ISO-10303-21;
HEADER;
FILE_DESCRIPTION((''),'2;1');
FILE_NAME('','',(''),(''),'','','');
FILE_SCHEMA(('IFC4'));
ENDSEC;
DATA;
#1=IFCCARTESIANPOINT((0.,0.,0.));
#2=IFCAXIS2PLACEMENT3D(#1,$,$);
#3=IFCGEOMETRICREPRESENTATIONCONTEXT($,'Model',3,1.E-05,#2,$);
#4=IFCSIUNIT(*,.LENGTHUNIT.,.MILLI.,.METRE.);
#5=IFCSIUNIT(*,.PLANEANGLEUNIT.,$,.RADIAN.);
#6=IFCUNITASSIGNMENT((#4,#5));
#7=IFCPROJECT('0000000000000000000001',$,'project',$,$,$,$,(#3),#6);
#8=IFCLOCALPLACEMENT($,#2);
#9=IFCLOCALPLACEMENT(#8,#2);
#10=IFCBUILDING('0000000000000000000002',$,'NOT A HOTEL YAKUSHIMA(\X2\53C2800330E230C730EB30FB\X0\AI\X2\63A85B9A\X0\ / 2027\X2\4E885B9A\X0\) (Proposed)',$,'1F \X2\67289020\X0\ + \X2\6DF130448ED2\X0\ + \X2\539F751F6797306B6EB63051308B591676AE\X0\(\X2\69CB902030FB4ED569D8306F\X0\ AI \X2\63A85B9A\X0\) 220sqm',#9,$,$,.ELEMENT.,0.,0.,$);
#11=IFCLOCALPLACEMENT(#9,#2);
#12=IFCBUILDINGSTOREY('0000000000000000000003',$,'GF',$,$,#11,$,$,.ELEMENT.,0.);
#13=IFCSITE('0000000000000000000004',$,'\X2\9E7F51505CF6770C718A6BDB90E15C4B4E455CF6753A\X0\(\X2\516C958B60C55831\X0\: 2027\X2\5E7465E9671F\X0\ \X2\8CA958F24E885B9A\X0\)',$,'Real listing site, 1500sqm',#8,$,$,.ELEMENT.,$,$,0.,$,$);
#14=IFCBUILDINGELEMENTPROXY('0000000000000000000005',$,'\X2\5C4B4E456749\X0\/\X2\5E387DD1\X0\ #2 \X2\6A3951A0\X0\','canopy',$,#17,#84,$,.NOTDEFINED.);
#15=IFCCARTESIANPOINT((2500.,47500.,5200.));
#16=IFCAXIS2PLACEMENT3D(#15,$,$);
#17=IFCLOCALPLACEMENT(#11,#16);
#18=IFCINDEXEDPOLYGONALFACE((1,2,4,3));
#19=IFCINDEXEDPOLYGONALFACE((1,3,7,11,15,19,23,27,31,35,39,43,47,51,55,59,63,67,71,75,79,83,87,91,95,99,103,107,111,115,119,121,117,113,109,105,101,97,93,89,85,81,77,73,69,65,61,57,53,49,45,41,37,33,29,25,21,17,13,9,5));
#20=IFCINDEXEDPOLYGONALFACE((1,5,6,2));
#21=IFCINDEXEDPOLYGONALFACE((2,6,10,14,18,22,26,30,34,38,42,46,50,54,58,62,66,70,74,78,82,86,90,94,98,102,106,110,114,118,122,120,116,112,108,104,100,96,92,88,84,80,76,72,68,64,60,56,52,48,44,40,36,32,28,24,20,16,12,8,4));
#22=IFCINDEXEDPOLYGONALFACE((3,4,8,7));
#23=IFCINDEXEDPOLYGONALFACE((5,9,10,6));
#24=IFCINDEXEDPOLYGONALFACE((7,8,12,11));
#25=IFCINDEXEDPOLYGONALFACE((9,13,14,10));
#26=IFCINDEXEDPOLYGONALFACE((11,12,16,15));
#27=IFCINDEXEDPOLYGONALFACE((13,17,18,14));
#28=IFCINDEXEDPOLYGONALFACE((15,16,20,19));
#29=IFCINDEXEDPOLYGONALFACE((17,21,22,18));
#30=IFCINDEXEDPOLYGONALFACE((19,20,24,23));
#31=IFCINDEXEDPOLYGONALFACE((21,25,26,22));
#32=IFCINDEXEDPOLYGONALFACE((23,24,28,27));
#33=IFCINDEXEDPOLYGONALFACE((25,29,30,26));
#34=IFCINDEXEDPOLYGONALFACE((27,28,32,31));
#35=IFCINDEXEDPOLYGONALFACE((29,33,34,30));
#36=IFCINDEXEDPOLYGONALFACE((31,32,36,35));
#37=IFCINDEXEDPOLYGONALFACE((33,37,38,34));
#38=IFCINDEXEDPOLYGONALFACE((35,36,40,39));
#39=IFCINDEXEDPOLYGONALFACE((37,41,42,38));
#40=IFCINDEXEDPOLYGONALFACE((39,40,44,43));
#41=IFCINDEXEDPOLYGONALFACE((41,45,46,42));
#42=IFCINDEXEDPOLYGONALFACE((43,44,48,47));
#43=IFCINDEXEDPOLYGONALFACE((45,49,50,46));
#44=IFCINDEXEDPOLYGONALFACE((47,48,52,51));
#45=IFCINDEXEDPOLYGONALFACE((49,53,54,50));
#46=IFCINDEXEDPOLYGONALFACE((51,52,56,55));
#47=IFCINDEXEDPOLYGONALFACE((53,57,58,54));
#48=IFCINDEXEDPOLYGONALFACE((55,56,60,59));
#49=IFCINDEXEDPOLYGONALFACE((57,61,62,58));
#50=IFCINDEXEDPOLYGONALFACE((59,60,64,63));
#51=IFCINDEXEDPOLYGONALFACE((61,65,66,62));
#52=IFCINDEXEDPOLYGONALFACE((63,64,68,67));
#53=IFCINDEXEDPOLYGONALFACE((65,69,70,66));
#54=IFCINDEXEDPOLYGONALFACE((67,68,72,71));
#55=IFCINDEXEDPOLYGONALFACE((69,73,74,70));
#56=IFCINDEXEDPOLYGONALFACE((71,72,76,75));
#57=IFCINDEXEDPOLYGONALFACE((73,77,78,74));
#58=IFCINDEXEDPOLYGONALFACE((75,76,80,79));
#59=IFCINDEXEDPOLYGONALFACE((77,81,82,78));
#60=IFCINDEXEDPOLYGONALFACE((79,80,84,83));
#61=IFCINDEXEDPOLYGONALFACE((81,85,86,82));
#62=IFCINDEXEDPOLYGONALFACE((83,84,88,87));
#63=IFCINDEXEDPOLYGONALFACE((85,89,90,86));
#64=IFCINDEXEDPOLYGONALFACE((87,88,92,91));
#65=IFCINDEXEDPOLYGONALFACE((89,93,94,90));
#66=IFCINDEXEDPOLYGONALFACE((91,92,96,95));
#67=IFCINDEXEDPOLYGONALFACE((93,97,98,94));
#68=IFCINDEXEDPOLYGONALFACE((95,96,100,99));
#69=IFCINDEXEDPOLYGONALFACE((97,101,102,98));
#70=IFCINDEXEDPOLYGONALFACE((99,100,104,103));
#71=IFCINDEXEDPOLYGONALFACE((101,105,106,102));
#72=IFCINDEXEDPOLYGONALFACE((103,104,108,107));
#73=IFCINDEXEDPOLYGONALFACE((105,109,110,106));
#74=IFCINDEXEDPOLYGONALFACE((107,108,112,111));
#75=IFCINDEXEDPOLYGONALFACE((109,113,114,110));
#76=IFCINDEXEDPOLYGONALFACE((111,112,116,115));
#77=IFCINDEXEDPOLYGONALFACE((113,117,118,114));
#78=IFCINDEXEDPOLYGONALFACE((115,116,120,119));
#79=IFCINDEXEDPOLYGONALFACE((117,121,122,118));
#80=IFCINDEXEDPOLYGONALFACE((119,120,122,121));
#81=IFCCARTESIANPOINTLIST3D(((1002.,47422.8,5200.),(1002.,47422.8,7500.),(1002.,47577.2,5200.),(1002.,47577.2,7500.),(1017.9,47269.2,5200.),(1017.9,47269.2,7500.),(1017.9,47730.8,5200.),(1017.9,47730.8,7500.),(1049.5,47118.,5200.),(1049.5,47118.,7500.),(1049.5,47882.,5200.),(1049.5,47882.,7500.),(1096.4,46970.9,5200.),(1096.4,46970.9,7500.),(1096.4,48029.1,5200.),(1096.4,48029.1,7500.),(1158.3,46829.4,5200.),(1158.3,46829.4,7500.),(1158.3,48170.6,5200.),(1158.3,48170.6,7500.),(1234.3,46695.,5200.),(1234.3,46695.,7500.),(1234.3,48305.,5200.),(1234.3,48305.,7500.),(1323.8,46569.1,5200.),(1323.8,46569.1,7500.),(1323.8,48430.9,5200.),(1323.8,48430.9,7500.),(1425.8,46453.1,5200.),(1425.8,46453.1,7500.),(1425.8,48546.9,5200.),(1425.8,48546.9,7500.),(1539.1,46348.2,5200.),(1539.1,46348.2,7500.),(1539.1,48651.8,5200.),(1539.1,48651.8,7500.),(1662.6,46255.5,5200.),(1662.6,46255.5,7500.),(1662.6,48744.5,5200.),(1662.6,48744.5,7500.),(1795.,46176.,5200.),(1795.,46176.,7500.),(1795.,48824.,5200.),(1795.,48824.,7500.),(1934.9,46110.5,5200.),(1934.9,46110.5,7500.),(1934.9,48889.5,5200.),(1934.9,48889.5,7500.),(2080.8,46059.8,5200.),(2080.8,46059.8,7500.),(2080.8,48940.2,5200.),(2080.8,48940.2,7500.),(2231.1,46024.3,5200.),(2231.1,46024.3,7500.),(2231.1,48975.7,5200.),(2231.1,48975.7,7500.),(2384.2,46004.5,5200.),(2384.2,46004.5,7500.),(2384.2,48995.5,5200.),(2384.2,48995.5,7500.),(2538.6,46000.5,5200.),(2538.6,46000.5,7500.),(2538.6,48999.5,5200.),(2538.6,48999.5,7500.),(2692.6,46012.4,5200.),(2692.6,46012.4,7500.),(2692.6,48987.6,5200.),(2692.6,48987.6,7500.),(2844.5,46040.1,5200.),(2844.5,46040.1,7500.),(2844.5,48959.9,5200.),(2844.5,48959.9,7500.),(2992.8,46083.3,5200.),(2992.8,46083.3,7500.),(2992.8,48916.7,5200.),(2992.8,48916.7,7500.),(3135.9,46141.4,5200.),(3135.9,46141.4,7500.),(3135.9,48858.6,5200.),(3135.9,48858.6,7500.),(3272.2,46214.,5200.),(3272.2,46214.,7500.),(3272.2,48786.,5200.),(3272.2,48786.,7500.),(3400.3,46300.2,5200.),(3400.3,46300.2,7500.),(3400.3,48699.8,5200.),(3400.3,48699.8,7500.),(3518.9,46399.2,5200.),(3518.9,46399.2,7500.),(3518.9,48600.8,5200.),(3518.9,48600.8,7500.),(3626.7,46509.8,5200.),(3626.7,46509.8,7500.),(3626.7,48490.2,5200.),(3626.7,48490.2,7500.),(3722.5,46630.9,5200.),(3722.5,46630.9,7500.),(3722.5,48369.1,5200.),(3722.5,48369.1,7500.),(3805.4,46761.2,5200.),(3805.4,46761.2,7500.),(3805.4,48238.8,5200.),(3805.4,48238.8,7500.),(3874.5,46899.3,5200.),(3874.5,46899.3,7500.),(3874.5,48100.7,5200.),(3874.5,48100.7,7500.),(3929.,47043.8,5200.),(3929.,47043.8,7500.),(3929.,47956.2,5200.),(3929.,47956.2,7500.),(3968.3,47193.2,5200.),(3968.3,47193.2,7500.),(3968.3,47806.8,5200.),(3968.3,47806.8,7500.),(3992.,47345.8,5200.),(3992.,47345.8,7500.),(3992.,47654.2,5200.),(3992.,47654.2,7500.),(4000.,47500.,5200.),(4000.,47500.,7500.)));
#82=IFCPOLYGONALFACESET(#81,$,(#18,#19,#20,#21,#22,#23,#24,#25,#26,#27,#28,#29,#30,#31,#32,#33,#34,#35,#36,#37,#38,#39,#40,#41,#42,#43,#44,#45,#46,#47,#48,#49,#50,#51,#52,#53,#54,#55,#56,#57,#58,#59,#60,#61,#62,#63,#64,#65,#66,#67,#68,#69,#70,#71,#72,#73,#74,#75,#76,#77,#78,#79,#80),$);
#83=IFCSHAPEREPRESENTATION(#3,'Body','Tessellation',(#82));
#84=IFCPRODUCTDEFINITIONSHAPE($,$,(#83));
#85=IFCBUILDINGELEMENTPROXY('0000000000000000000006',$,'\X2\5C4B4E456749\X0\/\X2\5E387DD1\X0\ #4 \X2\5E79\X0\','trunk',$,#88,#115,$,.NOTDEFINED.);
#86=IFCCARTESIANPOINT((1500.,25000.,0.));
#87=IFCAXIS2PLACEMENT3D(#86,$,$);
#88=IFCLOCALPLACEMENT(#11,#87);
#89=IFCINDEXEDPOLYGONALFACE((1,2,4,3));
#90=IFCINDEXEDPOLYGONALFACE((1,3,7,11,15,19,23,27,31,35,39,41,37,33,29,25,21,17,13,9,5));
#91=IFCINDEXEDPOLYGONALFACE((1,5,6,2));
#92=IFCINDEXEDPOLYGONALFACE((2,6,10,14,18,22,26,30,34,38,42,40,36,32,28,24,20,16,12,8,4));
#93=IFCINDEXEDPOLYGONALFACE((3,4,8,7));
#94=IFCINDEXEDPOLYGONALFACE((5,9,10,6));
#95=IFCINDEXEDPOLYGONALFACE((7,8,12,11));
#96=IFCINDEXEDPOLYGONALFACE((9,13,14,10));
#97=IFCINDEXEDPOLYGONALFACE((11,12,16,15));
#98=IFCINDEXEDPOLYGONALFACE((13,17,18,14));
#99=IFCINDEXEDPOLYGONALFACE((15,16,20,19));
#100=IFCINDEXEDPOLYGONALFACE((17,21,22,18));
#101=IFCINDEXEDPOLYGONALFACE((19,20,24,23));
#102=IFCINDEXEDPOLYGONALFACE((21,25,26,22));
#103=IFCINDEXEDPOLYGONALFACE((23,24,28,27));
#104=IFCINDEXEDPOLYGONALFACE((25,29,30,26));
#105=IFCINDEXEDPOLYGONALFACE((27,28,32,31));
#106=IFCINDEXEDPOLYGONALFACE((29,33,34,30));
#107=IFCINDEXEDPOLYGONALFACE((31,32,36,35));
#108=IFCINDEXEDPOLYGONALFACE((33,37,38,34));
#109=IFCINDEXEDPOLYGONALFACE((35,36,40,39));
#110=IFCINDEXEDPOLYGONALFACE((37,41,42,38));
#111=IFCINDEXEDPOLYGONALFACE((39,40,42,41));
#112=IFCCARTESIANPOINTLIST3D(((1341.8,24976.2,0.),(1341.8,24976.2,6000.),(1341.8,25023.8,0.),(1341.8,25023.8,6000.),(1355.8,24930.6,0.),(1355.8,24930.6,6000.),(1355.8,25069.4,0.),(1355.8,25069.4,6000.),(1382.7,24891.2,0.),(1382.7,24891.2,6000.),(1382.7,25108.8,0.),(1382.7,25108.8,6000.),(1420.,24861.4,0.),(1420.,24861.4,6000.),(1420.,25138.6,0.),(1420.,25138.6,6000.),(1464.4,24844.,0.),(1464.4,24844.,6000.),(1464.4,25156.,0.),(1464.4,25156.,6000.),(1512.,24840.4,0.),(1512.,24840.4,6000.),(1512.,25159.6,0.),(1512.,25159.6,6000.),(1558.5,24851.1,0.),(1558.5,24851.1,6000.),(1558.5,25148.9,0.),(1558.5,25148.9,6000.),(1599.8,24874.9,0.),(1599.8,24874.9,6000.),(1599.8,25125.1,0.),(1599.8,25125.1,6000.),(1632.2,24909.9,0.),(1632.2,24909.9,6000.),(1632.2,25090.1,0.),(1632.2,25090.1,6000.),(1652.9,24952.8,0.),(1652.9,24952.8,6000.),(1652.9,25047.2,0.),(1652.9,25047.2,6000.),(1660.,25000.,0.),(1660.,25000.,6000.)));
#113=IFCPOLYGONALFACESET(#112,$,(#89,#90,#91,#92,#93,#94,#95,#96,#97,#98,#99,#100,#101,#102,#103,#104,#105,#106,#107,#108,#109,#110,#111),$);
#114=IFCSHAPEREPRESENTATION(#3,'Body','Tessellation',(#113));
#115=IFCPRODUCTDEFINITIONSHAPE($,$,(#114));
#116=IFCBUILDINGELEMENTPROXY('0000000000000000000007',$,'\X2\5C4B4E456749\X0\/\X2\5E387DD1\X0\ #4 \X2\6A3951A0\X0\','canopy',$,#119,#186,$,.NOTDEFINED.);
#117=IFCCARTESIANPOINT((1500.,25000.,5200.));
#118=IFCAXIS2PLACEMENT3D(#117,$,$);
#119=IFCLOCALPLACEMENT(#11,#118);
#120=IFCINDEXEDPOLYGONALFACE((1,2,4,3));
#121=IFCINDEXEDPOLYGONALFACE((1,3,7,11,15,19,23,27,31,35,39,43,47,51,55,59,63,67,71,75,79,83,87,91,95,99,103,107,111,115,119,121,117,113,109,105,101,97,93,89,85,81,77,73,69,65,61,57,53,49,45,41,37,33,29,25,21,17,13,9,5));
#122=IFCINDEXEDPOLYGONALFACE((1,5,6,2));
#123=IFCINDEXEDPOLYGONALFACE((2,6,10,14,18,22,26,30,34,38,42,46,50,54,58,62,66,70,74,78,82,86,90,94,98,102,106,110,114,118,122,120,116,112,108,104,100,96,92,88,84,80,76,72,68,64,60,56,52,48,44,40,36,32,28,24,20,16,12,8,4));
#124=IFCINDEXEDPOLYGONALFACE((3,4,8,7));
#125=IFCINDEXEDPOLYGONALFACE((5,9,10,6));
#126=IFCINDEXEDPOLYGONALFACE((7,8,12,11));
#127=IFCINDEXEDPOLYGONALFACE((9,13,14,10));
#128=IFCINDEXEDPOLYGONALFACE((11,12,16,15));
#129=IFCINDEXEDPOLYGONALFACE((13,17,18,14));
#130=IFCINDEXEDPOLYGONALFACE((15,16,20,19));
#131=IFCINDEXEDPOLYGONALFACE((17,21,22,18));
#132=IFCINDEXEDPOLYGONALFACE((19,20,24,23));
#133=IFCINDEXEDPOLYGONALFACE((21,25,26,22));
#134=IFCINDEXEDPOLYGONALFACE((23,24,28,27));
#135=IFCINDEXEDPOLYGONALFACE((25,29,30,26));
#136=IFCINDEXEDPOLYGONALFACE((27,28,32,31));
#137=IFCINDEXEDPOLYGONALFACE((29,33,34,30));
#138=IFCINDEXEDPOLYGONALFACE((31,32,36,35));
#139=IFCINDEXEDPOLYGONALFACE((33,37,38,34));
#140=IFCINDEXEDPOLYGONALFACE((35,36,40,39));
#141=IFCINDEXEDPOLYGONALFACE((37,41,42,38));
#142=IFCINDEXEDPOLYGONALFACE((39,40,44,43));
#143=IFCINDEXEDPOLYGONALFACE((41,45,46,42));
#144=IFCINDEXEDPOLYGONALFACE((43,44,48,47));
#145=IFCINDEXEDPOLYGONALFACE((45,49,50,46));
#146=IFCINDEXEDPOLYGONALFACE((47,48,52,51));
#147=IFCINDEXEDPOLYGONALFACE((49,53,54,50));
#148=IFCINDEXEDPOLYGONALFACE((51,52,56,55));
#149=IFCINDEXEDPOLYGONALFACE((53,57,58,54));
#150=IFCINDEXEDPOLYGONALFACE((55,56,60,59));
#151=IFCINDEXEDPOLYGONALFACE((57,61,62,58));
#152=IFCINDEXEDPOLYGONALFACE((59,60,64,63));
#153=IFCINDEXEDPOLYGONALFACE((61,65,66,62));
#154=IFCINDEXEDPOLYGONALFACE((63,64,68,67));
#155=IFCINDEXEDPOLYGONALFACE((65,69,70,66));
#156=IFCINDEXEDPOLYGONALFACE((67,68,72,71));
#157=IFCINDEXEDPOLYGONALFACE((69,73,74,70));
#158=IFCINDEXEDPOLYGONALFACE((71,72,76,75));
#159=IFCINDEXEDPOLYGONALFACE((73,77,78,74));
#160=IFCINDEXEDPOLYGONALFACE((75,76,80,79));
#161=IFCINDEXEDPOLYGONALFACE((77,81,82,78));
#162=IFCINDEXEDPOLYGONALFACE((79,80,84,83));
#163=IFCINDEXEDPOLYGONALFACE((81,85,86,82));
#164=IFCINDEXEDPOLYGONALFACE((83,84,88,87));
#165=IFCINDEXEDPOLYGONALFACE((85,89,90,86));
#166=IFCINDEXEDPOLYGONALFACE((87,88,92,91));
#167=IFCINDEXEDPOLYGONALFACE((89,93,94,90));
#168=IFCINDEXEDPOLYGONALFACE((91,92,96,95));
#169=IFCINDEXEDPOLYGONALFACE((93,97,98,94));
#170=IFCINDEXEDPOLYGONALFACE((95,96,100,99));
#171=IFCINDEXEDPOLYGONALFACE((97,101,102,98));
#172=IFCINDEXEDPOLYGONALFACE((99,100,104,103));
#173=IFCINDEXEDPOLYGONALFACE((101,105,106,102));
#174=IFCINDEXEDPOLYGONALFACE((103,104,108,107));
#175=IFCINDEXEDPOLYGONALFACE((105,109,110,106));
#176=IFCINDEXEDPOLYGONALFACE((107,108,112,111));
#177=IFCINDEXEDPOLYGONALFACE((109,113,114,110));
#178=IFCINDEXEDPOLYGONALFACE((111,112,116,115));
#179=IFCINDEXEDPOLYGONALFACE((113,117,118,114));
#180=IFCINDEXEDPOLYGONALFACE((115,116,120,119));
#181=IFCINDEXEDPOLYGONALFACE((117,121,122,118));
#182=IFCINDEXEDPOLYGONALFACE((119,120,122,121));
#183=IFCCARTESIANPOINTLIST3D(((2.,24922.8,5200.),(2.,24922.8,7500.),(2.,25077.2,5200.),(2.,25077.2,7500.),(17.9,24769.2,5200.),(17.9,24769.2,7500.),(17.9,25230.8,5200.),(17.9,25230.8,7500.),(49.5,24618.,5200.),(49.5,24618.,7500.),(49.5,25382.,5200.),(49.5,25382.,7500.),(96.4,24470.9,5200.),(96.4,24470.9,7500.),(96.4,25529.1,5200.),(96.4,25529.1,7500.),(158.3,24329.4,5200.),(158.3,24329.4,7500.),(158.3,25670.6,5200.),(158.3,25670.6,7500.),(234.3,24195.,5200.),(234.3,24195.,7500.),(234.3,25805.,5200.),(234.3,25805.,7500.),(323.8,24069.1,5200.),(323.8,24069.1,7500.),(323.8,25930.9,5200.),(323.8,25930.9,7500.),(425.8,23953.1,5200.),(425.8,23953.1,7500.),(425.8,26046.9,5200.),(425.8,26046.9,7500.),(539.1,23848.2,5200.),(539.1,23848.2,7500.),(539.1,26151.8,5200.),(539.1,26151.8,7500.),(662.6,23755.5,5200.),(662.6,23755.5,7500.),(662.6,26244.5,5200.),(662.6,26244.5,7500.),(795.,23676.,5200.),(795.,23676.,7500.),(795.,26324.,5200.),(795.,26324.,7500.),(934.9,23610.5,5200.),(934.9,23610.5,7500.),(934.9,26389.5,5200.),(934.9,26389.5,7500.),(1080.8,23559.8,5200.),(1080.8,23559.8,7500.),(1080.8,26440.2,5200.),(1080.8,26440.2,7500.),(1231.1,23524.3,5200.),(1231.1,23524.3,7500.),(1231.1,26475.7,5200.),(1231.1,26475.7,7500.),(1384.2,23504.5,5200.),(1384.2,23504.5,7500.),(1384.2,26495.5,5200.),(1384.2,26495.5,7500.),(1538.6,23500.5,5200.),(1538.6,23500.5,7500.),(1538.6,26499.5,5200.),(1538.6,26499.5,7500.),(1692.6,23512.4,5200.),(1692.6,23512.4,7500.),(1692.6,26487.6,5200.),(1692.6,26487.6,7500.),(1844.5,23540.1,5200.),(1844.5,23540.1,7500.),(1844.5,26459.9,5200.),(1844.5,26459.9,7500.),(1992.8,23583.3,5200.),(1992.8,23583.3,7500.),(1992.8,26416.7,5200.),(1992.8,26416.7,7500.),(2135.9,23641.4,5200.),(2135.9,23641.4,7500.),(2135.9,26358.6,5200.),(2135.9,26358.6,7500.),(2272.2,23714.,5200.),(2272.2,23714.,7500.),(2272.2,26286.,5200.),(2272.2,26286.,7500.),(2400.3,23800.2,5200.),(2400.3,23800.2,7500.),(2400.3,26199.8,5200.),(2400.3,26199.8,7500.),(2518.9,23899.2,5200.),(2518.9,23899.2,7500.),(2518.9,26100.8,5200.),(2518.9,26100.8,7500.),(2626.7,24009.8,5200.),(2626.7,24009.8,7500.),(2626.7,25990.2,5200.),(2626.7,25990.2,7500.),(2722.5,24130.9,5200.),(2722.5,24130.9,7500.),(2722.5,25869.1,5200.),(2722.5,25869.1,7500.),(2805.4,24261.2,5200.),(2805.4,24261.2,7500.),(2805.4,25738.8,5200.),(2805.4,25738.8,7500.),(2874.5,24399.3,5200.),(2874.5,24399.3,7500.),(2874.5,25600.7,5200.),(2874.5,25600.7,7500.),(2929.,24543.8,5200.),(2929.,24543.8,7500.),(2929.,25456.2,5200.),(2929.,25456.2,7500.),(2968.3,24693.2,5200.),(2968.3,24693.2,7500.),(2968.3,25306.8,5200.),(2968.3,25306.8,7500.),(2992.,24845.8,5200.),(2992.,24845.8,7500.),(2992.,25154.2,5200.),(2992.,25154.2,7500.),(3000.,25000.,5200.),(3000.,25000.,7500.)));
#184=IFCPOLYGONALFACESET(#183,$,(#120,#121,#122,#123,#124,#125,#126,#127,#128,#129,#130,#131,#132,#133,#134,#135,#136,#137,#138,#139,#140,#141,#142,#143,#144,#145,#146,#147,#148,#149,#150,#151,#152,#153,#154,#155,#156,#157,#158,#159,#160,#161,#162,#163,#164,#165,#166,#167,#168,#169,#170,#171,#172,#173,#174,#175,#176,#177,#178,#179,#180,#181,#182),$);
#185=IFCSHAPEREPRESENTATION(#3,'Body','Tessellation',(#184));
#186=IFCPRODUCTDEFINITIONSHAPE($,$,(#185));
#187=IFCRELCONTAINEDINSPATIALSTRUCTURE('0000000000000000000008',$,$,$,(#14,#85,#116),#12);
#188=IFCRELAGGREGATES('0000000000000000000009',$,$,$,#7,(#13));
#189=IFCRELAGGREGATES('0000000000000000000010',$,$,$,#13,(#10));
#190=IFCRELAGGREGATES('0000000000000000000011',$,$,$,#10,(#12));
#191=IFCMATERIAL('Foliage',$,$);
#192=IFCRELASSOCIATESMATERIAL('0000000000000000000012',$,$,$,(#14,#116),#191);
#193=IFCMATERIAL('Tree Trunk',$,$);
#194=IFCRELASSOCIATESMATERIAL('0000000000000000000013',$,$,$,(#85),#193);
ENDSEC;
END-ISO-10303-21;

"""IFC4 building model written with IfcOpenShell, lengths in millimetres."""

from ifc_helpers import new_model, si_unit, frame, origin, origin_2d, place, context, project, spatial, circle, extrude, material, element, save


model = new_model("IFC4")

# Units and contexts
model_context = context("Model", 3, precision=1e-05, world=origin())
ifc_project = project(units=[si_unit("LENGTHUNIT", "METRE", prefix="MILLI"), si_unit("PLANEANGLEUNIT", "RADIAN")], contexts=[model_context])

# Site, building, storey
site_placement = place(None, origin())
site = spatial("IfcSite", under=ifc_project, at=site_placement, Name="鹿児島県熊毛郡屋久島町(公開情報: 2027年早期 販売予定)", ObjectType="Real listing site, 1500sqm", CompositionType="ELEMENT", RefElevation=0.0)
building_placement = place(site_placement, origin())
building = spatial("IfcBuilding", under=site, at=building_placement, Name="NOT A HOTEL YAKUSHIMA(参考モデル・AI推定 / 2027予定) (Proposed)", ObjectType="1F 木造 + 深い軒 + 原生林に溶ける外皮(構造・仕様は AI 推定) 220sqm", CompositionType="ELEMENT", ElevationOfRefHeight=0.0, ElevationOfTerrain=0.0)
storey_placement = place(building_placement, origin())
storey = spatial("IfcBuildingStorey", under=building, at=storey_placement, Name="GF", CompositionType="ELEMENT", Elevation=0.0)

# Building element proxies
ifc_material_1 = material(Name="Tree Trunk")
ifc_material_2 = material(Name="Foliage")
proxy_1_placement = place(storey_placement, frame((2500.0, 47500.0, 5200.0)))
element("IfcBuildingElementProxy", 1, at=proxy_1_placement, inside=storey, material=ifc_material_2, Name="屋久杉/常緑 #2 樹冠", Description="canopy", PredefinedType="NOTDEFINED", context=model_context, shape_type="SweptSolid", body=[
    extrude(circle(Radius=1500.0, at=origin_2d()), frame((2500.0, 47500.0, 5200.0)), (0.0, 0.0, 1.0), 2300.0),
])
proxy_2_placement = place(storey_placement, frame((1500.0, 25000.0, 0.0)))
element("IfcBuildingElementProxy", 2, at=proxy_2_placement, inside=storey, material=ifc_material_1, Name="屋久杉/常緑 #4 幹", Description="trunk", PredefinedType="NOTDEFINED", context=model_context, shape_type="SweptSolid", body=[
    extrude(circle(Radius=160.0, at=origin_2d()), frame((1500.0, 25000.0, 0.0)), (0.0, 0.0, 1.0), 6000.0),
])
proxy_3_placement = place(storey_placement, frame((1500.0, 25000.0, 5200.0)))
element("IfcBuildingElementProxy", 3, at=proxy_3_placement, inside=storey, material=ifc_material_2, Name="屋久杉/常緑 #4 樹冠", Description="canopy", PredefinedType="NOTDEFINED", context=model_context, shape_type="SweptSolid", body=[
    extrude(circle(Radius=1500.0, at=origin_2d()), frame((1500.0, 25000.0, 5200.0)), (0.0, 0.0, 1.0), 2300.0),
])

save(model, "model.ifc")
